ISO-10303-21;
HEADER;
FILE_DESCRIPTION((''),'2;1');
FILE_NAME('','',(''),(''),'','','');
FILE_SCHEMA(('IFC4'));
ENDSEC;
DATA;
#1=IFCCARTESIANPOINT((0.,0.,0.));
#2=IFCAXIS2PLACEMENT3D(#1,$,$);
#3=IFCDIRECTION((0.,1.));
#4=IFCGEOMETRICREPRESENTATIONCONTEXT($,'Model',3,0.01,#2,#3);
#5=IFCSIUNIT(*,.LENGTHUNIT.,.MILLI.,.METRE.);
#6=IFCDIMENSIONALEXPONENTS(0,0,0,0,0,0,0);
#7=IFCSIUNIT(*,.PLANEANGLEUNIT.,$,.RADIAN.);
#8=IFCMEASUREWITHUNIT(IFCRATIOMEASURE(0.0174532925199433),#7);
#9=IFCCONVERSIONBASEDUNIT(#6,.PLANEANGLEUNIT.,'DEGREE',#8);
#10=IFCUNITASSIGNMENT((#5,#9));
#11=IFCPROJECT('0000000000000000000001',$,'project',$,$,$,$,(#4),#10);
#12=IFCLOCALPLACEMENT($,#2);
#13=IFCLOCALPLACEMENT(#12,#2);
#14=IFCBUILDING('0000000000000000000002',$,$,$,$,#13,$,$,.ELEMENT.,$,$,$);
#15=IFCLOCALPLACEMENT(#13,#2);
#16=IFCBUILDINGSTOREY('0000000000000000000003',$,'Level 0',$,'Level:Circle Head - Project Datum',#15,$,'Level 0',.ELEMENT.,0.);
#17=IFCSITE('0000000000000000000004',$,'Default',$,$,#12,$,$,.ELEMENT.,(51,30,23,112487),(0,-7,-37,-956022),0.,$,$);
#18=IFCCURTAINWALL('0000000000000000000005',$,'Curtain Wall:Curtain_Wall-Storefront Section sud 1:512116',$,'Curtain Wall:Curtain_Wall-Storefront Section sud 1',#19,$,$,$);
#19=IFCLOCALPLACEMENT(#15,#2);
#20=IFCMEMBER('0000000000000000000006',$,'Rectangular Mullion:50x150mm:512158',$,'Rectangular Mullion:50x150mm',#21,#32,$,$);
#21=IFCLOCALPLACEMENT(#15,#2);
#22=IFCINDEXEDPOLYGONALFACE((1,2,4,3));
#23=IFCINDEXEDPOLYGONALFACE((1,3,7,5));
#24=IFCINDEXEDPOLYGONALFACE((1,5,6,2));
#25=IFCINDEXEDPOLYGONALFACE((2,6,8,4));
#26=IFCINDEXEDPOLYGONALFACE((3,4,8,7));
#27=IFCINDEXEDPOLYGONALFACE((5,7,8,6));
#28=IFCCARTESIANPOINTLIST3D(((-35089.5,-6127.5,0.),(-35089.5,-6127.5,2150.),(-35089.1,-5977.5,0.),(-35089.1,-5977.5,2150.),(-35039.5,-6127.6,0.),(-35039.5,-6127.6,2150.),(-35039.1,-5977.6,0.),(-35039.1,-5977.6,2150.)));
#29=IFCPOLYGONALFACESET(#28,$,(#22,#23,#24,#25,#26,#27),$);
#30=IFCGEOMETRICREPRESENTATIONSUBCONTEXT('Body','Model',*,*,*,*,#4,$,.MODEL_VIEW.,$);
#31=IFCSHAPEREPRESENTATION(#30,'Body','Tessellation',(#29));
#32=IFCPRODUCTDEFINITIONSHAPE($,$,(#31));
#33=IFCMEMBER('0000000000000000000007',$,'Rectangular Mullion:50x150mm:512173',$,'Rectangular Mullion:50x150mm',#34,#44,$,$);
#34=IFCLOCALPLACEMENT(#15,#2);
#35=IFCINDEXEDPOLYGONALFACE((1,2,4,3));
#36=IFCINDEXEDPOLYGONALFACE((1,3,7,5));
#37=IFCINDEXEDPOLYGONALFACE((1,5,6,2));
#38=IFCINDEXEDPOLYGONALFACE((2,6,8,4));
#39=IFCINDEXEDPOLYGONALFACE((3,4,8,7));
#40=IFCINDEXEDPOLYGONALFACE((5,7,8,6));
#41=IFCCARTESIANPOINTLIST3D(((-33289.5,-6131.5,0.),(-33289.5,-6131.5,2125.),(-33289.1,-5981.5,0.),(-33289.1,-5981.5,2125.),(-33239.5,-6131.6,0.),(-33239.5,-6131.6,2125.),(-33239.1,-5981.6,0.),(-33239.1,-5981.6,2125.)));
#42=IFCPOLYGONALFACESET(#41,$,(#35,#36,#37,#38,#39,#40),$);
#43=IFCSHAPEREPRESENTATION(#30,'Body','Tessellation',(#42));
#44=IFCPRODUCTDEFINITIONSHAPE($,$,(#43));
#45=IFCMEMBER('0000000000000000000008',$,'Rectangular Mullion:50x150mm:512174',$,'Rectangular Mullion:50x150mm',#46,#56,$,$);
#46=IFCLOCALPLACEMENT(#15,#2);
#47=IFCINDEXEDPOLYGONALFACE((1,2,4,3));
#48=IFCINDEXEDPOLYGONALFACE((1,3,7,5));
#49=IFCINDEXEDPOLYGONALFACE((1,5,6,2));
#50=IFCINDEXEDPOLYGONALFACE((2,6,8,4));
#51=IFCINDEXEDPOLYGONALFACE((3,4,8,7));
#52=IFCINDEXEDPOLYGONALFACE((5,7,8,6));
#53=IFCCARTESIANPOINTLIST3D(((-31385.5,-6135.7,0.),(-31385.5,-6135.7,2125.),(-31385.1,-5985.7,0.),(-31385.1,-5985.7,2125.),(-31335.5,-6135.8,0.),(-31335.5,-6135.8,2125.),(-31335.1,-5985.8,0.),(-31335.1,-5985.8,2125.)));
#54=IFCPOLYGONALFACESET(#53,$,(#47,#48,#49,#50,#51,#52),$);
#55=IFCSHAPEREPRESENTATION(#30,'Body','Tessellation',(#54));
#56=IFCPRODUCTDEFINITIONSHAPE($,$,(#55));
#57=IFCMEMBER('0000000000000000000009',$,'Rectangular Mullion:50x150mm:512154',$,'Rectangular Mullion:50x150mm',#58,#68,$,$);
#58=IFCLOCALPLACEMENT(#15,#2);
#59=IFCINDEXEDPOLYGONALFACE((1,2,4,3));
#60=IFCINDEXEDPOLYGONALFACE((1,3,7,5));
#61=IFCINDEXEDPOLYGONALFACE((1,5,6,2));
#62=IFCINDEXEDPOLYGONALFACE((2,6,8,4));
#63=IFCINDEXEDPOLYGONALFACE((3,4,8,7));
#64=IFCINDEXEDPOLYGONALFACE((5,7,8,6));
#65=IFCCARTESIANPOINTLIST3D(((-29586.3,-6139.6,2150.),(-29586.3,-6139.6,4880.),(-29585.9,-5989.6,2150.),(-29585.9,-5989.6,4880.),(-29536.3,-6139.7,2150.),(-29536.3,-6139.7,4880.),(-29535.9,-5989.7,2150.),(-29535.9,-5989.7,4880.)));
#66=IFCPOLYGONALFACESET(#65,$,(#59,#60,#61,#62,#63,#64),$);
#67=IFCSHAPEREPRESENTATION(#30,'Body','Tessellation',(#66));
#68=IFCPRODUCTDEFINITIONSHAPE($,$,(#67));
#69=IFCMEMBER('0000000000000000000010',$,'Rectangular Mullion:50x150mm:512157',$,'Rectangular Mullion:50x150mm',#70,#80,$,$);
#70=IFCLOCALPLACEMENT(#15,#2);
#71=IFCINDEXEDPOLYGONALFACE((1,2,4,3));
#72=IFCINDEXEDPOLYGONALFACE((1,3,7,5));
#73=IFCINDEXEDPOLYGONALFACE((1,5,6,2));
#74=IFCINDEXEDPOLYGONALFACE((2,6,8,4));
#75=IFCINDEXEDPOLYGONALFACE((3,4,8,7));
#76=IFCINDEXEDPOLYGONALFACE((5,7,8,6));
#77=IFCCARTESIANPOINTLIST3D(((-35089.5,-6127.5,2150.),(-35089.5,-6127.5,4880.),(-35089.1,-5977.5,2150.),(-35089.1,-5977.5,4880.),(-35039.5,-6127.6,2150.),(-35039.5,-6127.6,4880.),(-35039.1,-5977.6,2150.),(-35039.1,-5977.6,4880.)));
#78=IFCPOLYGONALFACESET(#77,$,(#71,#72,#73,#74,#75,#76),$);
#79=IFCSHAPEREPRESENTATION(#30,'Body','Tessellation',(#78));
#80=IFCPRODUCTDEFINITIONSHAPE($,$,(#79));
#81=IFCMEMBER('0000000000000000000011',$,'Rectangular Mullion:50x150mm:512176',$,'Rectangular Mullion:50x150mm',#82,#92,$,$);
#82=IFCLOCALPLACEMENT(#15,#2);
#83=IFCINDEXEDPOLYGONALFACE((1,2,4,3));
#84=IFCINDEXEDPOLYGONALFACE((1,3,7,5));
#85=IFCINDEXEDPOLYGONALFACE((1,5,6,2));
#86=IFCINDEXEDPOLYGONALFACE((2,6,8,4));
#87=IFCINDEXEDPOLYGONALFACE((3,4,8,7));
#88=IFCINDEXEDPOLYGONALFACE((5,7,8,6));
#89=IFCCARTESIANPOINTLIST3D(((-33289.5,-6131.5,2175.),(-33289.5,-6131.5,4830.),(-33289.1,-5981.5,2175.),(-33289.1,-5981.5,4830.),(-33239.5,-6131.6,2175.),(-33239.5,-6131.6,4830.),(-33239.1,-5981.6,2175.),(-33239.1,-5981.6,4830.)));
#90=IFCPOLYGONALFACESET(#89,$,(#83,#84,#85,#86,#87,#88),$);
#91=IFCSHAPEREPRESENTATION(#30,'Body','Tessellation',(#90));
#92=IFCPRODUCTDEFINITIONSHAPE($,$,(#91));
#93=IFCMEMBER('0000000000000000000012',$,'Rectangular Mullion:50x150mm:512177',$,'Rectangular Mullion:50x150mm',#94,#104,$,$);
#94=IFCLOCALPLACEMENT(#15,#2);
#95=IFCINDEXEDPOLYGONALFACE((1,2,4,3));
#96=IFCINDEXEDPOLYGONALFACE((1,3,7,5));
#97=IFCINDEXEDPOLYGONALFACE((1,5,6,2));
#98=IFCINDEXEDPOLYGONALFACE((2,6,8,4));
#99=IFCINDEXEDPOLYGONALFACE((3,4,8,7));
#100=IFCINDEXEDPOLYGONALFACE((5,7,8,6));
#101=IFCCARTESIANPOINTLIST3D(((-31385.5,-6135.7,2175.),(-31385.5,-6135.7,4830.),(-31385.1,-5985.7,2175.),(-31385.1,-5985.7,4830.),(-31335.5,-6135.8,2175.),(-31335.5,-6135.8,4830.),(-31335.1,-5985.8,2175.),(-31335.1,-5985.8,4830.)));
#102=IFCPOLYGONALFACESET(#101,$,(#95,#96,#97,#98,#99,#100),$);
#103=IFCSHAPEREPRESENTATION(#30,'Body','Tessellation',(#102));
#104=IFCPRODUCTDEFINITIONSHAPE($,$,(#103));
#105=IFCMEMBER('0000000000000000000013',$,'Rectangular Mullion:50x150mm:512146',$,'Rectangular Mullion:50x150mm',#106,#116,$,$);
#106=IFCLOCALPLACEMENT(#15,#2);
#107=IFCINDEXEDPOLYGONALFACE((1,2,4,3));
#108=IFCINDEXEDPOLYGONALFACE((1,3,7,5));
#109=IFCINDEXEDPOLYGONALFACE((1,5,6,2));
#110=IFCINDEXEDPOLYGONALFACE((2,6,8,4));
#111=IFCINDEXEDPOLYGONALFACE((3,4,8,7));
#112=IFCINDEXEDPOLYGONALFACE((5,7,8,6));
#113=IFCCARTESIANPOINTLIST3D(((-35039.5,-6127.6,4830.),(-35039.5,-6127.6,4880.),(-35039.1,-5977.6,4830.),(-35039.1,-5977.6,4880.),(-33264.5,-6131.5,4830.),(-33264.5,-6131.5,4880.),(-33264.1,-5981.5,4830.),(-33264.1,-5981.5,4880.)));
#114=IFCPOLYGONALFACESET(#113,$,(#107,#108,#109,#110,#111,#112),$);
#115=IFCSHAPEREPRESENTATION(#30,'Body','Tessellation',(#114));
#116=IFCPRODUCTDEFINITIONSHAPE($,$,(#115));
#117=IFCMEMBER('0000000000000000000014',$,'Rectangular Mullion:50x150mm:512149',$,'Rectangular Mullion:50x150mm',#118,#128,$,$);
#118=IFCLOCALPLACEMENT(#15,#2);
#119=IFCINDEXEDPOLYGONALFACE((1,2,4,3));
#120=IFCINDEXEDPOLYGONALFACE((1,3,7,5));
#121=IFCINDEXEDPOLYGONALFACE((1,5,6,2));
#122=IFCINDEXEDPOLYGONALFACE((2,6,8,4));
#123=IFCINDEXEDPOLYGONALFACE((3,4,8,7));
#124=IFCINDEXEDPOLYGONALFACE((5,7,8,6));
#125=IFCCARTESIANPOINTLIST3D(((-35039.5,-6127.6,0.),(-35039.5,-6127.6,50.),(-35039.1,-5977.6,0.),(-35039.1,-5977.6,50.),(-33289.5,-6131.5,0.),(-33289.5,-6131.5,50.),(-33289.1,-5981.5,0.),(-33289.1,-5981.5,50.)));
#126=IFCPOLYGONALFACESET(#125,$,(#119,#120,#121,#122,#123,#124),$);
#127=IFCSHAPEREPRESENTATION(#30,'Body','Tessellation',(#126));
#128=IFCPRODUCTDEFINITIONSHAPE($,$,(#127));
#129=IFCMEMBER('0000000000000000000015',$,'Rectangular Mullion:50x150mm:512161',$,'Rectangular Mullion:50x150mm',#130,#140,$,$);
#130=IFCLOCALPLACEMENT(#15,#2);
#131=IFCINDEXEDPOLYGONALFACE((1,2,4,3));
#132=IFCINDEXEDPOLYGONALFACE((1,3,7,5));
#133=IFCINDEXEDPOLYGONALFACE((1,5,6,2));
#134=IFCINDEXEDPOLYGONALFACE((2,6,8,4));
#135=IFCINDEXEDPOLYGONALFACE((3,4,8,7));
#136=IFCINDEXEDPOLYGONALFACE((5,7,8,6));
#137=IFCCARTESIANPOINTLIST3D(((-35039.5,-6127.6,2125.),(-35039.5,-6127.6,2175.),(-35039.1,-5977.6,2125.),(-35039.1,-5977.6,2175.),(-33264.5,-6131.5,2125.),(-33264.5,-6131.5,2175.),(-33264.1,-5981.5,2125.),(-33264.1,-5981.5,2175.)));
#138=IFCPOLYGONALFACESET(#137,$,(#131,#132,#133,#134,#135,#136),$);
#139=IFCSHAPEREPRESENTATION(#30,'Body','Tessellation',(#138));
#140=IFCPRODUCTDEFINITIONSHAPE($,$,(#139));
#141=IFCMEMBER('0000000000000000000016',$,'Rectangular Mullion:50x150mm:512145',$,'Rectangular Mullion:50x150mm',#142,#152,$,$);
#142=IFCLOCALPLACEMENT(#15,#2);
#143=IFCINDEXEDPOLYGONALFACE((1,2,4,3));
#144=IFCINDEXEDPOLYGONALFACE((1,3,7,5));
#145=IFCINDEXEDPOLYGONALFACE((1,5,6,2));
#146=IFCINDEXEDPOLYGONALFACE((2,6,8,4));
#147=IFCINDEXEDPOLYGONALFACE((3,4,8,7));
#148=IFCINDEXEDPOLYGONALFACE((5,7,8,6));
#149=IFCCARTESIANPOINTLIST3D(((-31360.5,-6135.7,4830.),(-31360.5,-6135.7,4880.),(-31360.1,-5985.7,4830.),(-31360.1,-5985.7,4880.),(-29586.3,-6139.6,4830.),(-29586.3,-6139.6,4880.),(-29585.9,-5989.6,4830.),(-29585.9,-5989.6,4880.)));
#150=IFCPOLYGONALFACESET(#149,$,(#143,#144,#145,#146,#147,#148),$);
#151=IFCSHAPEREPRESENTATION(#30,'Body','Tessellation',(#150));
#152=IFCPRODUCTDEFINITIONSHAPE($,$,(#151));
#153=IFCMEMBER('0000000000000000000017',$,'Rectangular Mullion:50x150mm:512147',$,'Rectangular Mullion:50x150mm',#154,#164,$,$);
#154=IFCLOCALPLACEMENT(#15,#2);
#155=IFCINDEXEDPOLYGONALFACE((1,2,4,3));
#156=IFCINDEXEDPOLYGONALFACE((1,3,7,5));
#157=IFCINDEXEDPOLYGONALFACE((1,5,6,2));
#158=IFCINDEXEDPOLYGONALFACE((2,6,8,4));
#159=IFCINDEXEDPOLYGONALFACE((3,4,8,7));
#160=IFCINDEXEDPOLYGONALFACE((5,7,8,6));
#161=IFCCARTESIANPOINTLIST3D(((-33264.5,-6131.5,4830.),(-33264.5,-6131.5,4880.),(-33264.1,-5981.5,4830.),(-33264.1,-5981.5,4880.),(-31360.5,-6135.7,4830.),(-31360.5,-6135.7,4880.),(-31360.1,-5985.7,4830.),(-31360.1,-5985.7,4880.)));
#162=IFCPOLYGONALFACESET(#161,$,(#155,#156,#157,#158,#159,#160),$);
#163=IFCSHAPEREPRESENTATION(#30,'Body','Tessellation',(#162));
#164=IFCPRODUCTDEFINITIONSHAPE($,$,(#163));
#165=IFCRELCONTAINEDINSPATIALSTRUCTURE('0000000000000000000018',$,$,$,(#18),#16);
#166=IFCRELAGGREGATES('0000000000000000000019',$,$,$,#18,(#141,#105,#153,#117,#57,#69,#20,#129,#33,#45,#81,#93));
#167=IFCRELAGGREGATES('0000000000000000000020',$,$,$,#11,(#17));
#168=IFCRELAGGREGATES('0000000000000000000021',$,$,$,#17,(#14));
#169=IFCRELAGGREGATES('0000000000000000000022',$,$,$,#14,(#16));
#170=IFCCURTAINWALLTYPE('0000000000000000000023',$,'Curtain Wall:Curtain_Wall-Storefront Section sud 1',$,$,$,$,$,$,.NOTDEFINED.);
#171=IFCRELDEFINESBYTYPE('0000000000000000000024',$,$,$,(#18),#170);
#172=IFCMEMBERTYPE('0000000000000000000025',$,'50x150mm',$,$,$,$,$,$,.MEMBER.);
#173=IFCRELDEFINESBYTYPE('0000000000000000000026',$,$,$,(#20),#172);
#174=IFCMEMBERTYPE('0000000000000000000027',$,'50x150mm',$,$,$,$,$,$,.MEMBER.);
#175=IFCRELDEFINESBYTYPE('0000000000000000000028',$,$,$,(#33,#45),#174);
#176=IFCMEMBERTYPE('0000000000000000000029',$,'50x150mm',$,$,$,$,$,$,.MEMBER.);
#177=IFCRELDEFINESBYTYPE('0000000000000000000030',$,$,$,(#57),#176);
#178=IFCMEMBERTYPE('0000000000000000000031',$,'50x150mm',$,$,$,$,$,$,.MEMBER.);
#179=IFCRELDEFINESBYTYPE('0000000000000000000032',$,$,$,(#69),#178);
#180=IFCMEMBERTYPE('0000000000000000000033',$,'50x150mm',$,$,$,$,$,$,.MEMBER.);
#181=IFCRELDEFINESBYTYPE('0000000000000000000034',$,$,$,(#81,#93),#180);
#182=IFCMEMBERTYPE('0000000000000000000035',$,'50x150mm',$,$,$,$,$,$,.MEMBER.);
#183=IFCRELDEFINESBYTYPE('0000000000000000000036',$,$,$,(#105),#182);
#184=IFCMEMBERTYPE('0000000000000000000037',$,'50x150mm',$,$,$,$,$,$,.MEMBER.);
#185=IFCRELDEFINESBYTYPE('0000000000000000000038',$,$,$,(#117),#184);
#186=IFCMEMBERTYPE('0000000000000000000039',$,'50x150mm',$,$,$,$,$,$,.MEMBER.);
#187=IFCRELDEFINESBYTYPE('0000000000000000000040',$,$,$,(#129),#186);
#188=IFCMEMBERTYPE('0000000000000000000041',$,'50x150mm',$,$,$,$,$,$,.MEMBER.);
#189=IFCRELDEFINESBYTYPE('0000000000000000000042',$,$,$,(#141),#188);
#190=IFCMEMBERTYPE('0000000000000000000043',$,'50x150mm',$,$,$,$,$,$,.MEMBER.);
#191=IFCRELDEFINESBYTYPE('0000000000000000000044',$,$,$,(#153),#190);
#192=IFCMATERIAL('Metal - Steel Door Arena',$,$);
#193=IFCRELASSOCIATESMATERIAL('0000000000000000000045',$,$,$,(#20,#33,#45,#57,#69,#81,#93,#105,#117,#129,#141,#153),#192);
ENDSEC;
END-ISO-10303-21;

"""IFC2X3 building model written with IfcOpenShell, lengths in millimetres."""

from ifc_helpers import new_model, entity, si_unit, converted_unit, direction, frame, origin, origin_2d_with_axis, place, context, subcontext, project, spatial, rectangle, extrude, source, transform, mapped, material, type_object, type_shapes, element, aggregate, save


model = new_model("IFC2X3")

# Units and contexts
model_context = context("Model", 3, precision=0.01, world=origin(), true_north=direction((0.0, 1.0)))
body_context = subcontext(model_context, "Body", "Model", "MODEL_VIEW")
ifc_project = project(units=[si_unit("LENGTHUNIT", "METRE", prefix="MILLI"), converted_unit("PLANEANGLEUNIT", "DEGREE", entity("IfcRatioMeasure", 0.0174532925199433), si_unit("PLANEANGLEUNIT", "RADIAN"), dimensions=[0, 0, 0, 0, 0, 0, 0])], contexts=[model_context])

# Site, building, storey
site_placement = place(None, origin())
site = spatial("IfcSite", under=ifc_project, at=site_placement, Name="Default", CompositionType="ELEMENT", RefLatitude=(51, 30, 23, 112487), RefLongitude=(0, -7, -37, -956022), RefElevation=0.0)
building_placement = place(site_placement, origin())
building = spatial("IfcBuilding", under=site, at=building_placement, CompositionType="ELEMENT")
storey_placement = place(building_placement, origin())
storey = spatial("IfcBuildingStorey", under=building, at=storey_placement, Name="Level 0", ObjectType="Level:Circle Head - Project Datum", LongName="Level 0", CompositionType="ELEMENT", Elevation=0.0)

# Curtain wall, members
curtain_wall_type = type_object("IfcCurtainWallType", Name="Curtain Wall:Curtain_Wall-Storefront Section sud 1", PredefinedType="NOTDEFINED")
curtain_wall_placement = place(storey_placement, origin())
curtain_wall = element("IfcCurtainWall", 1, at=curtain_wall_placement, inside=storey, type_object=curtain_wall_type, Name="Curtain Wall:Curtain_Wall-Storefront Section sud 1:512116", ObjectType="Curtain Wall:Curtain_Wall-Storefront Section sud 1")
ifc_material_1 = material(Name="Metal - Steel Door Arena")
member_type_1 = type_object("IfcMemberType", Name="50x150mm", PredefinedType="MEMBER")
shared_shape_1 = source(origin(), body_context, "Body", "SweptSolid", [
    extrude(rectangle(XDim=150.0, YDim=50.0, at=origin_2d_with_axis()), frame((-25.0, 0.0, -2150.0), z_axis=(0.0, 0.0, 1.0), x_axis=(0.0, -1.0, 0.0)), (0.0, 0.0, 1.0), 2150.0),
])
type_shapes(member_type_1, [shared_shape_1])
member_1_placement = place(storey_placement, frame((-35089.3, -6052.5, 2150.0), z_axis=(0.0, 0.0, 1.0), x_axis=(-0.999998, 0.002199, 0.0)))
member_1 = element("IfcMember", 2, at=member_1_placement, type_object=member_type_1, material=ifc_material_1, Name="Rectangular Mullion:50x150mm:512158", ObjectType="Rectangular Mullion:50x150mm", context=body_context, shape_type="MappedRepresentation", body=[
    mapped(shared_shape_1, transform((0.0, 0.0, 0.0), scale=1.0)),
])
member_type_2 = type_object("IfcMemberType", Name="50x150mm", PredefinedType="MEMBER")
shared_shape_2 = source(origin(), body_context, "Body", "SweptSolid", [
    extrude(rectangle(XDim=150.0, YDim=50.0, at=origin_2d_with_axis()), frame((0.0, 0.0, -2125.0), z_axis=(0.0, 0.0, 1.0), x_axis=(0.0, -1.0, 0.0)), (0.0, 0.0, 1.0), 2125.0),
])
type_shapes(member_type_2, [shared_shape_2])
member_2_placement = place(storey_placement, frame((-33264.3, -6056.5, 0.0), z_axis=(0.0, 0.0, -1.0), x_axis=(0.999998, -0.002199, 0.0)))
member_2 = element("IfcMember", 3, at=member_2_placement, type_object=member_type_2, material=ifc_material_1, Name="Rectangular Mullion:50x150mm:512173", ObjectType="Rectangular Mullion:50x150mm", context=body_context, shape_type="MappedRepresentation", body=[
    mapped(shared_shape_2, transform((0.0, 0.0, 0.0), scale=1.0)),
])
member_3_placement = place(storey_placement, frame((-31360.3, -6060.7, 0.0), z_axis=(0.0, 0.0, -1.0), x_axis=(0.999998, -0.002199, 0.0)))
member_3 = element("IfcMember", 4, at=member_3_placement, type_object=member_type_2, material=ifc_material_1, Name="Rectangular Mullion:50x150mm:512174", ObjectType="Rectangular Mullion:50x150mm", context=body_context, shape_type="MappedRepresentation", body=[
    mapped(shared_shape_2, transform((0.0, 0.0, 0.0), scale=1.0)),
])
member_type_3 = type_object("IfcMemberType", Name="50x150mm", PredefinedType="MEMBER")
shared_shape_3 = source(origin(), body_context, "Body", "SweptSolid", [
    extrude(rectangle(XDim=150.0, YDim=50.0, at=origin_2d_with_axis()), frame((-25.0, 0.0, -2730.0), z_axis=(0.0, 0.0, 1.0), x_axis=(0.0, -1.0, 0.0)), (0.0, 0.0, 1.0), 2730.0),
])
type_shapes(member_type_3, [shared_shape_3])
member_4_placement = place(storey_placement, frame((-29536.1, -6064.7, 2150.0), z_axis=(0.0, 0.0, -1.0), x_axis=(0.999998, -0.002199, 0.0)))
member_4 = element("IfcMember", 5, at=member_4_placement, type_object=member_type_3, material=ifc_material_1, Name="Rectangular Mullion:50x150mm:512154", ObjectType="Rectangular Mullion:50x150mm", context=body_context, shape_type="MappedRepresentation", body=[
    mapped(shared_shape_3, transform((0.0, 0.0, 0.0), scale=1.0)),
])
member_type_4 = type_object("IfcMemberType", Name="50x150mm", PredefinedType="MEMBER")
shared_shape_4 = source(origin(), body_context, "Body", "SweptSolid", [
    extrude(rectangle(XDim=150.0, YDim=50.0, at=origin_2d_with_axis()), frame((-25.0, 0.0, -2730.0), z_axis=(0.0, 0.0, 1.0), x_axis=(0.0, -1.0, 0.0)), (0.0, 0.0, 1.0), 2730.0),
])
type_shapes(member_type_4, [shared_shape_4])
member_5_placement = place(storey_placement, frame((-35089.3, -6052.5, 4880.0), z_axis=(0.0, 0.0, 1.0), x_axis=(-0.999998, 0.002199, 0.0)))
member_5 = element("IfcMember", 6, at=member_5_placement, type_object=member_type_4, material=ifc_material_1, Name="Rectangular Mullion:50x150mm:512157", ObjectType="Rectangular Mullion:50x150mm", context=body_context, shape_type="MappedRepresentation", body=[
    mapped(shared_shape_4, transform((0.0, 0.0, 0.0), scale=1.0)),
])
member_type_5 = type_object("IfcMemberType", Name="50x150mm", PredefinedType="MEMBER")
shared_shape_5 = source(origin(), body_context, "Body", "SweptSolid", [
    extrude(rectangle(XDim=150.0, YDim=50.0, at=origin_2d_with_axis()), frame((0.0, 0.0, -2655.0), z_axis=(0.0, 0.0, 1.0), x_axis=(0.0, -1.0, 0.0)), (0.0, 0.0, 1.0), 2655.0),
])
type_shapes(member_type_5, [shared_shape_5])
member_6_placement = place(storey_placement, frame((-33264.3, -6056.5, 2175.0), z_axis=(0.0, 0.0, -1.0), x_axis=(0.999998, -0.002199, 0.0)))
member_6 = element("IfcMember", 7, at=member_6_placement, type_object=member_type_5, material=ifc_material_1, Name="Rectangular Mullion:50x150mm:512176", ObjectType="Rectangular Mullion:50x150mm", context=body_context, shape_type="MappedRepresentation", body=[
    mapped(shared_shape_5, transform((0.0, 0.0, 0.0), scale=1.0)),
])
member_7_placement = place(storey_placement, frame((-31360.3, -6060.7, 2175.0), z_axis=(0.0, 0.0, -1.0), x_axis=(0.999998, -0.002199, 0.0)))
member_7 = element("IfcMember", 8, at=member_7_placement, type_object=member_type_5, material=ifc_material_1, Name="Rectangular Mullion:50x150mm:512177", ObjectType="Rectangular Mullion:50x150mm", context=body_context, shape_type="MappedRepresentation", body=[
    mapped(shared_shape_5, transform((0.0, 0.0, 0.0), scale=1.0)),
])
member_type_6 = type_object("IfcMemberType", Name="50x150mm", PredefinedType="MEMBER")
shared_shape_6 = source(origin(), body_context, "Body", "SweptSolid", [
    extrude(rectangle(XDim=150.0, YDim=50.0, at=origin_2d_with_axis()), frame((-25.0, 0.0, -1775.0), z_axis=(0.0, 0.0, 1.0), x_axis=(0.0, -1.0, 0.0)), (0.0, 0.0, 1.0), 1775.0),
])
type_shapes(member_type_6, [shared_shape_6])
member_8_placement = place(storey_placement, frame((-33264.3, -6056.5, 4880.0), z_axis=(0.999998, -0.002199, 0.0), x_axis=(0.0, 0.0, 1.0)))
member_8 = element("IfcMember", 9, at=member_8_placement, type_object=member_type_6, material=ifc_material_1, Name="Rectangular Mullion:50x150mm:512146", ObjectType="Rectangular Mullion:50x150mm", context=body_context, shape_type="MappedRepresentation", body=[
    mapped(shared_shape_6, transform((0.0, 0.0, 0.0), scale=1.0)),
])
member_type_7 = type_object("IfcMemberType", Name="50x150mm", PredefinedType="MEMBER")
shared_shape_7 = source(origin(), body_context, "Body", "SweptSolid", [
    extrude(rectangle(XDim=150.0, YDim=50.0, at=origin_2d_with_axis()), frame((-25.0, 0.0, -1750.0), z_axis=(0.0, 0.0, 1.0), x_axis=(0.0, -1.0, 0.0)), (0.0, 0.0, 1.0), 1750.0),
])
type_shapes(member_type_7, [shared_shape_7])
member_9_placement = place(storey_placement, frame((-35039.3, -6052.6, 0.0), z_axis=(-0.999998, 0.002199, 0.0), x_axis=(0.0, 0.0, -1.0)))
member_9 = element("IfcMember", 10, at=member_9_placement, type_object=member_type_7, material=ifc_material_1, Name="Rectangular Mullion:50x150mm:512149", ObjectType="Rectangular Mullion:50x150mm", context=body_context, shape_type="MappedRepresentation", body=[
    mapped(shared_shape_7, transform((0.0, 0.0, 0.0), scale=1.0)),
])
member_type_8 = type_object("IfcMemberType", Name="50x150mm", PredefinedType="MEMBER")
shared_shape_8 = source(origin(), body_context, "Body", "SweptSolid", [
    extrude(rectangle(XDim=150.0, YDim=50.0, at=origin_2d_with_axis()), frame((0.0, 0.0, -1775.0), z_axis=(0.0, 0.0, 1.0), x_axis=(0.0, -1.0, 0.0)), (0.0, 0.0, 1.0), 1775.0),
])
type_shapes(member_type_8, [shared_shape_8])
member_10_placement = place(storey_placement, frame((-33264.3, -6056.5, 2150.0), z_axis=(0.999998, -0.002199, 0.0), x_axis=(0.0, 0.0, 1.0)))
member_10 = element("IfcMember", 11, at=member_10_placement, type_object=member_type_8, material=ifc_material_1, Name="Rectangular Mullion:50x150mm:512161", ObjectType="Rectangular Mullion:50x150mm", context=body_context, shape_type="MappedRepresentation", body=[
    mapped(shared_shape_8, transform((0.0, 0.0, 0.0), scale=1.0)),
])
member_type_9 = type_object("IfcMemberType", Name="50x150mm", PredefinedType="MEMBER")
shared_shape_9 = source(origin(), body_context, "Body", "SweptSolid", [
    extrude(rectangle(XDim=150.0, YDim=50.0, at=origin_2d_with_axis()), frame((-25.0, 0.0, -1774.2), z_axis=(0.0, 0.0, 1.0), x_axis=(0.0, -1.0, 0.0)), (0.0, 0.0, 1.0), 1774.2),
])
type_shapes(member_type_9, [shared_shape_9])
member_11_placement = place(storey_placement, frame((-29586.1, -6064.6, 4880.0), z_axis=(0.999998, -0.002199, 0.0), x_axis=(0.0, 0.0, 1.0)))
member_11 = element("IfcMember", 12, at=member_11_placement, type_object=member_type_9, material=ifc_material_1, Name="Rectangular Mullion:50x150mm:512145", ObjectType="Rectangular Mullion:50x150mm", context=body_context, shape_type="MappedRepresentation", body=[
    mapped(shared_shape_9, transform((0.0, 0.0, 0.0), scale=1.0)),
])
member_type_10 = type_object("IfcMemberType", Name="50x150mm", PredefinedType="MEMBER")
shared_shape_10 = source(origin(), body_context, "Body", "SweptSolid", [
    extrude(rectangle(XDim=150.0, YDim=50.0, at=origin_2d_with_axis()), frame((-25.0, 0.0, -1904.0), z_axis=(0.0, 0.0, 1.0), x_axis=(0.0, -1.0, 0.0)), (0.0, 0.0, 1.0), 1904.0),
])
type_shapes(member_type_10, [shared_shape_10])
member_12_placement = place(storey_placement, frame((-31360.3, -6060.7, 4880.0), z_axis=(0.999998, -0.002199, 0.0), x_axis=(0.0, 0.0, 1.0)))
member_12 = element("IfcMember", 13, at=member_12_placement, type_object=member_type_10, material=ifc_material_1, Name="Rectangular Mullion:50x150mm:512147", ObjectType="Rectangular Mullion:50x150mm", context=body_context, shape_type="MappedRepresentation", body=[
    mapped(shared_shape_10, transform((0.0, 0.0, 0.0), scale=1.0)),
])
aggregate(curtain_wall, [member_11, member_8, member_12, member_9, member_4, member_5, member_1, member_10, member_2, member_3, member_6, member_7])

save(model, "model.ifc")
